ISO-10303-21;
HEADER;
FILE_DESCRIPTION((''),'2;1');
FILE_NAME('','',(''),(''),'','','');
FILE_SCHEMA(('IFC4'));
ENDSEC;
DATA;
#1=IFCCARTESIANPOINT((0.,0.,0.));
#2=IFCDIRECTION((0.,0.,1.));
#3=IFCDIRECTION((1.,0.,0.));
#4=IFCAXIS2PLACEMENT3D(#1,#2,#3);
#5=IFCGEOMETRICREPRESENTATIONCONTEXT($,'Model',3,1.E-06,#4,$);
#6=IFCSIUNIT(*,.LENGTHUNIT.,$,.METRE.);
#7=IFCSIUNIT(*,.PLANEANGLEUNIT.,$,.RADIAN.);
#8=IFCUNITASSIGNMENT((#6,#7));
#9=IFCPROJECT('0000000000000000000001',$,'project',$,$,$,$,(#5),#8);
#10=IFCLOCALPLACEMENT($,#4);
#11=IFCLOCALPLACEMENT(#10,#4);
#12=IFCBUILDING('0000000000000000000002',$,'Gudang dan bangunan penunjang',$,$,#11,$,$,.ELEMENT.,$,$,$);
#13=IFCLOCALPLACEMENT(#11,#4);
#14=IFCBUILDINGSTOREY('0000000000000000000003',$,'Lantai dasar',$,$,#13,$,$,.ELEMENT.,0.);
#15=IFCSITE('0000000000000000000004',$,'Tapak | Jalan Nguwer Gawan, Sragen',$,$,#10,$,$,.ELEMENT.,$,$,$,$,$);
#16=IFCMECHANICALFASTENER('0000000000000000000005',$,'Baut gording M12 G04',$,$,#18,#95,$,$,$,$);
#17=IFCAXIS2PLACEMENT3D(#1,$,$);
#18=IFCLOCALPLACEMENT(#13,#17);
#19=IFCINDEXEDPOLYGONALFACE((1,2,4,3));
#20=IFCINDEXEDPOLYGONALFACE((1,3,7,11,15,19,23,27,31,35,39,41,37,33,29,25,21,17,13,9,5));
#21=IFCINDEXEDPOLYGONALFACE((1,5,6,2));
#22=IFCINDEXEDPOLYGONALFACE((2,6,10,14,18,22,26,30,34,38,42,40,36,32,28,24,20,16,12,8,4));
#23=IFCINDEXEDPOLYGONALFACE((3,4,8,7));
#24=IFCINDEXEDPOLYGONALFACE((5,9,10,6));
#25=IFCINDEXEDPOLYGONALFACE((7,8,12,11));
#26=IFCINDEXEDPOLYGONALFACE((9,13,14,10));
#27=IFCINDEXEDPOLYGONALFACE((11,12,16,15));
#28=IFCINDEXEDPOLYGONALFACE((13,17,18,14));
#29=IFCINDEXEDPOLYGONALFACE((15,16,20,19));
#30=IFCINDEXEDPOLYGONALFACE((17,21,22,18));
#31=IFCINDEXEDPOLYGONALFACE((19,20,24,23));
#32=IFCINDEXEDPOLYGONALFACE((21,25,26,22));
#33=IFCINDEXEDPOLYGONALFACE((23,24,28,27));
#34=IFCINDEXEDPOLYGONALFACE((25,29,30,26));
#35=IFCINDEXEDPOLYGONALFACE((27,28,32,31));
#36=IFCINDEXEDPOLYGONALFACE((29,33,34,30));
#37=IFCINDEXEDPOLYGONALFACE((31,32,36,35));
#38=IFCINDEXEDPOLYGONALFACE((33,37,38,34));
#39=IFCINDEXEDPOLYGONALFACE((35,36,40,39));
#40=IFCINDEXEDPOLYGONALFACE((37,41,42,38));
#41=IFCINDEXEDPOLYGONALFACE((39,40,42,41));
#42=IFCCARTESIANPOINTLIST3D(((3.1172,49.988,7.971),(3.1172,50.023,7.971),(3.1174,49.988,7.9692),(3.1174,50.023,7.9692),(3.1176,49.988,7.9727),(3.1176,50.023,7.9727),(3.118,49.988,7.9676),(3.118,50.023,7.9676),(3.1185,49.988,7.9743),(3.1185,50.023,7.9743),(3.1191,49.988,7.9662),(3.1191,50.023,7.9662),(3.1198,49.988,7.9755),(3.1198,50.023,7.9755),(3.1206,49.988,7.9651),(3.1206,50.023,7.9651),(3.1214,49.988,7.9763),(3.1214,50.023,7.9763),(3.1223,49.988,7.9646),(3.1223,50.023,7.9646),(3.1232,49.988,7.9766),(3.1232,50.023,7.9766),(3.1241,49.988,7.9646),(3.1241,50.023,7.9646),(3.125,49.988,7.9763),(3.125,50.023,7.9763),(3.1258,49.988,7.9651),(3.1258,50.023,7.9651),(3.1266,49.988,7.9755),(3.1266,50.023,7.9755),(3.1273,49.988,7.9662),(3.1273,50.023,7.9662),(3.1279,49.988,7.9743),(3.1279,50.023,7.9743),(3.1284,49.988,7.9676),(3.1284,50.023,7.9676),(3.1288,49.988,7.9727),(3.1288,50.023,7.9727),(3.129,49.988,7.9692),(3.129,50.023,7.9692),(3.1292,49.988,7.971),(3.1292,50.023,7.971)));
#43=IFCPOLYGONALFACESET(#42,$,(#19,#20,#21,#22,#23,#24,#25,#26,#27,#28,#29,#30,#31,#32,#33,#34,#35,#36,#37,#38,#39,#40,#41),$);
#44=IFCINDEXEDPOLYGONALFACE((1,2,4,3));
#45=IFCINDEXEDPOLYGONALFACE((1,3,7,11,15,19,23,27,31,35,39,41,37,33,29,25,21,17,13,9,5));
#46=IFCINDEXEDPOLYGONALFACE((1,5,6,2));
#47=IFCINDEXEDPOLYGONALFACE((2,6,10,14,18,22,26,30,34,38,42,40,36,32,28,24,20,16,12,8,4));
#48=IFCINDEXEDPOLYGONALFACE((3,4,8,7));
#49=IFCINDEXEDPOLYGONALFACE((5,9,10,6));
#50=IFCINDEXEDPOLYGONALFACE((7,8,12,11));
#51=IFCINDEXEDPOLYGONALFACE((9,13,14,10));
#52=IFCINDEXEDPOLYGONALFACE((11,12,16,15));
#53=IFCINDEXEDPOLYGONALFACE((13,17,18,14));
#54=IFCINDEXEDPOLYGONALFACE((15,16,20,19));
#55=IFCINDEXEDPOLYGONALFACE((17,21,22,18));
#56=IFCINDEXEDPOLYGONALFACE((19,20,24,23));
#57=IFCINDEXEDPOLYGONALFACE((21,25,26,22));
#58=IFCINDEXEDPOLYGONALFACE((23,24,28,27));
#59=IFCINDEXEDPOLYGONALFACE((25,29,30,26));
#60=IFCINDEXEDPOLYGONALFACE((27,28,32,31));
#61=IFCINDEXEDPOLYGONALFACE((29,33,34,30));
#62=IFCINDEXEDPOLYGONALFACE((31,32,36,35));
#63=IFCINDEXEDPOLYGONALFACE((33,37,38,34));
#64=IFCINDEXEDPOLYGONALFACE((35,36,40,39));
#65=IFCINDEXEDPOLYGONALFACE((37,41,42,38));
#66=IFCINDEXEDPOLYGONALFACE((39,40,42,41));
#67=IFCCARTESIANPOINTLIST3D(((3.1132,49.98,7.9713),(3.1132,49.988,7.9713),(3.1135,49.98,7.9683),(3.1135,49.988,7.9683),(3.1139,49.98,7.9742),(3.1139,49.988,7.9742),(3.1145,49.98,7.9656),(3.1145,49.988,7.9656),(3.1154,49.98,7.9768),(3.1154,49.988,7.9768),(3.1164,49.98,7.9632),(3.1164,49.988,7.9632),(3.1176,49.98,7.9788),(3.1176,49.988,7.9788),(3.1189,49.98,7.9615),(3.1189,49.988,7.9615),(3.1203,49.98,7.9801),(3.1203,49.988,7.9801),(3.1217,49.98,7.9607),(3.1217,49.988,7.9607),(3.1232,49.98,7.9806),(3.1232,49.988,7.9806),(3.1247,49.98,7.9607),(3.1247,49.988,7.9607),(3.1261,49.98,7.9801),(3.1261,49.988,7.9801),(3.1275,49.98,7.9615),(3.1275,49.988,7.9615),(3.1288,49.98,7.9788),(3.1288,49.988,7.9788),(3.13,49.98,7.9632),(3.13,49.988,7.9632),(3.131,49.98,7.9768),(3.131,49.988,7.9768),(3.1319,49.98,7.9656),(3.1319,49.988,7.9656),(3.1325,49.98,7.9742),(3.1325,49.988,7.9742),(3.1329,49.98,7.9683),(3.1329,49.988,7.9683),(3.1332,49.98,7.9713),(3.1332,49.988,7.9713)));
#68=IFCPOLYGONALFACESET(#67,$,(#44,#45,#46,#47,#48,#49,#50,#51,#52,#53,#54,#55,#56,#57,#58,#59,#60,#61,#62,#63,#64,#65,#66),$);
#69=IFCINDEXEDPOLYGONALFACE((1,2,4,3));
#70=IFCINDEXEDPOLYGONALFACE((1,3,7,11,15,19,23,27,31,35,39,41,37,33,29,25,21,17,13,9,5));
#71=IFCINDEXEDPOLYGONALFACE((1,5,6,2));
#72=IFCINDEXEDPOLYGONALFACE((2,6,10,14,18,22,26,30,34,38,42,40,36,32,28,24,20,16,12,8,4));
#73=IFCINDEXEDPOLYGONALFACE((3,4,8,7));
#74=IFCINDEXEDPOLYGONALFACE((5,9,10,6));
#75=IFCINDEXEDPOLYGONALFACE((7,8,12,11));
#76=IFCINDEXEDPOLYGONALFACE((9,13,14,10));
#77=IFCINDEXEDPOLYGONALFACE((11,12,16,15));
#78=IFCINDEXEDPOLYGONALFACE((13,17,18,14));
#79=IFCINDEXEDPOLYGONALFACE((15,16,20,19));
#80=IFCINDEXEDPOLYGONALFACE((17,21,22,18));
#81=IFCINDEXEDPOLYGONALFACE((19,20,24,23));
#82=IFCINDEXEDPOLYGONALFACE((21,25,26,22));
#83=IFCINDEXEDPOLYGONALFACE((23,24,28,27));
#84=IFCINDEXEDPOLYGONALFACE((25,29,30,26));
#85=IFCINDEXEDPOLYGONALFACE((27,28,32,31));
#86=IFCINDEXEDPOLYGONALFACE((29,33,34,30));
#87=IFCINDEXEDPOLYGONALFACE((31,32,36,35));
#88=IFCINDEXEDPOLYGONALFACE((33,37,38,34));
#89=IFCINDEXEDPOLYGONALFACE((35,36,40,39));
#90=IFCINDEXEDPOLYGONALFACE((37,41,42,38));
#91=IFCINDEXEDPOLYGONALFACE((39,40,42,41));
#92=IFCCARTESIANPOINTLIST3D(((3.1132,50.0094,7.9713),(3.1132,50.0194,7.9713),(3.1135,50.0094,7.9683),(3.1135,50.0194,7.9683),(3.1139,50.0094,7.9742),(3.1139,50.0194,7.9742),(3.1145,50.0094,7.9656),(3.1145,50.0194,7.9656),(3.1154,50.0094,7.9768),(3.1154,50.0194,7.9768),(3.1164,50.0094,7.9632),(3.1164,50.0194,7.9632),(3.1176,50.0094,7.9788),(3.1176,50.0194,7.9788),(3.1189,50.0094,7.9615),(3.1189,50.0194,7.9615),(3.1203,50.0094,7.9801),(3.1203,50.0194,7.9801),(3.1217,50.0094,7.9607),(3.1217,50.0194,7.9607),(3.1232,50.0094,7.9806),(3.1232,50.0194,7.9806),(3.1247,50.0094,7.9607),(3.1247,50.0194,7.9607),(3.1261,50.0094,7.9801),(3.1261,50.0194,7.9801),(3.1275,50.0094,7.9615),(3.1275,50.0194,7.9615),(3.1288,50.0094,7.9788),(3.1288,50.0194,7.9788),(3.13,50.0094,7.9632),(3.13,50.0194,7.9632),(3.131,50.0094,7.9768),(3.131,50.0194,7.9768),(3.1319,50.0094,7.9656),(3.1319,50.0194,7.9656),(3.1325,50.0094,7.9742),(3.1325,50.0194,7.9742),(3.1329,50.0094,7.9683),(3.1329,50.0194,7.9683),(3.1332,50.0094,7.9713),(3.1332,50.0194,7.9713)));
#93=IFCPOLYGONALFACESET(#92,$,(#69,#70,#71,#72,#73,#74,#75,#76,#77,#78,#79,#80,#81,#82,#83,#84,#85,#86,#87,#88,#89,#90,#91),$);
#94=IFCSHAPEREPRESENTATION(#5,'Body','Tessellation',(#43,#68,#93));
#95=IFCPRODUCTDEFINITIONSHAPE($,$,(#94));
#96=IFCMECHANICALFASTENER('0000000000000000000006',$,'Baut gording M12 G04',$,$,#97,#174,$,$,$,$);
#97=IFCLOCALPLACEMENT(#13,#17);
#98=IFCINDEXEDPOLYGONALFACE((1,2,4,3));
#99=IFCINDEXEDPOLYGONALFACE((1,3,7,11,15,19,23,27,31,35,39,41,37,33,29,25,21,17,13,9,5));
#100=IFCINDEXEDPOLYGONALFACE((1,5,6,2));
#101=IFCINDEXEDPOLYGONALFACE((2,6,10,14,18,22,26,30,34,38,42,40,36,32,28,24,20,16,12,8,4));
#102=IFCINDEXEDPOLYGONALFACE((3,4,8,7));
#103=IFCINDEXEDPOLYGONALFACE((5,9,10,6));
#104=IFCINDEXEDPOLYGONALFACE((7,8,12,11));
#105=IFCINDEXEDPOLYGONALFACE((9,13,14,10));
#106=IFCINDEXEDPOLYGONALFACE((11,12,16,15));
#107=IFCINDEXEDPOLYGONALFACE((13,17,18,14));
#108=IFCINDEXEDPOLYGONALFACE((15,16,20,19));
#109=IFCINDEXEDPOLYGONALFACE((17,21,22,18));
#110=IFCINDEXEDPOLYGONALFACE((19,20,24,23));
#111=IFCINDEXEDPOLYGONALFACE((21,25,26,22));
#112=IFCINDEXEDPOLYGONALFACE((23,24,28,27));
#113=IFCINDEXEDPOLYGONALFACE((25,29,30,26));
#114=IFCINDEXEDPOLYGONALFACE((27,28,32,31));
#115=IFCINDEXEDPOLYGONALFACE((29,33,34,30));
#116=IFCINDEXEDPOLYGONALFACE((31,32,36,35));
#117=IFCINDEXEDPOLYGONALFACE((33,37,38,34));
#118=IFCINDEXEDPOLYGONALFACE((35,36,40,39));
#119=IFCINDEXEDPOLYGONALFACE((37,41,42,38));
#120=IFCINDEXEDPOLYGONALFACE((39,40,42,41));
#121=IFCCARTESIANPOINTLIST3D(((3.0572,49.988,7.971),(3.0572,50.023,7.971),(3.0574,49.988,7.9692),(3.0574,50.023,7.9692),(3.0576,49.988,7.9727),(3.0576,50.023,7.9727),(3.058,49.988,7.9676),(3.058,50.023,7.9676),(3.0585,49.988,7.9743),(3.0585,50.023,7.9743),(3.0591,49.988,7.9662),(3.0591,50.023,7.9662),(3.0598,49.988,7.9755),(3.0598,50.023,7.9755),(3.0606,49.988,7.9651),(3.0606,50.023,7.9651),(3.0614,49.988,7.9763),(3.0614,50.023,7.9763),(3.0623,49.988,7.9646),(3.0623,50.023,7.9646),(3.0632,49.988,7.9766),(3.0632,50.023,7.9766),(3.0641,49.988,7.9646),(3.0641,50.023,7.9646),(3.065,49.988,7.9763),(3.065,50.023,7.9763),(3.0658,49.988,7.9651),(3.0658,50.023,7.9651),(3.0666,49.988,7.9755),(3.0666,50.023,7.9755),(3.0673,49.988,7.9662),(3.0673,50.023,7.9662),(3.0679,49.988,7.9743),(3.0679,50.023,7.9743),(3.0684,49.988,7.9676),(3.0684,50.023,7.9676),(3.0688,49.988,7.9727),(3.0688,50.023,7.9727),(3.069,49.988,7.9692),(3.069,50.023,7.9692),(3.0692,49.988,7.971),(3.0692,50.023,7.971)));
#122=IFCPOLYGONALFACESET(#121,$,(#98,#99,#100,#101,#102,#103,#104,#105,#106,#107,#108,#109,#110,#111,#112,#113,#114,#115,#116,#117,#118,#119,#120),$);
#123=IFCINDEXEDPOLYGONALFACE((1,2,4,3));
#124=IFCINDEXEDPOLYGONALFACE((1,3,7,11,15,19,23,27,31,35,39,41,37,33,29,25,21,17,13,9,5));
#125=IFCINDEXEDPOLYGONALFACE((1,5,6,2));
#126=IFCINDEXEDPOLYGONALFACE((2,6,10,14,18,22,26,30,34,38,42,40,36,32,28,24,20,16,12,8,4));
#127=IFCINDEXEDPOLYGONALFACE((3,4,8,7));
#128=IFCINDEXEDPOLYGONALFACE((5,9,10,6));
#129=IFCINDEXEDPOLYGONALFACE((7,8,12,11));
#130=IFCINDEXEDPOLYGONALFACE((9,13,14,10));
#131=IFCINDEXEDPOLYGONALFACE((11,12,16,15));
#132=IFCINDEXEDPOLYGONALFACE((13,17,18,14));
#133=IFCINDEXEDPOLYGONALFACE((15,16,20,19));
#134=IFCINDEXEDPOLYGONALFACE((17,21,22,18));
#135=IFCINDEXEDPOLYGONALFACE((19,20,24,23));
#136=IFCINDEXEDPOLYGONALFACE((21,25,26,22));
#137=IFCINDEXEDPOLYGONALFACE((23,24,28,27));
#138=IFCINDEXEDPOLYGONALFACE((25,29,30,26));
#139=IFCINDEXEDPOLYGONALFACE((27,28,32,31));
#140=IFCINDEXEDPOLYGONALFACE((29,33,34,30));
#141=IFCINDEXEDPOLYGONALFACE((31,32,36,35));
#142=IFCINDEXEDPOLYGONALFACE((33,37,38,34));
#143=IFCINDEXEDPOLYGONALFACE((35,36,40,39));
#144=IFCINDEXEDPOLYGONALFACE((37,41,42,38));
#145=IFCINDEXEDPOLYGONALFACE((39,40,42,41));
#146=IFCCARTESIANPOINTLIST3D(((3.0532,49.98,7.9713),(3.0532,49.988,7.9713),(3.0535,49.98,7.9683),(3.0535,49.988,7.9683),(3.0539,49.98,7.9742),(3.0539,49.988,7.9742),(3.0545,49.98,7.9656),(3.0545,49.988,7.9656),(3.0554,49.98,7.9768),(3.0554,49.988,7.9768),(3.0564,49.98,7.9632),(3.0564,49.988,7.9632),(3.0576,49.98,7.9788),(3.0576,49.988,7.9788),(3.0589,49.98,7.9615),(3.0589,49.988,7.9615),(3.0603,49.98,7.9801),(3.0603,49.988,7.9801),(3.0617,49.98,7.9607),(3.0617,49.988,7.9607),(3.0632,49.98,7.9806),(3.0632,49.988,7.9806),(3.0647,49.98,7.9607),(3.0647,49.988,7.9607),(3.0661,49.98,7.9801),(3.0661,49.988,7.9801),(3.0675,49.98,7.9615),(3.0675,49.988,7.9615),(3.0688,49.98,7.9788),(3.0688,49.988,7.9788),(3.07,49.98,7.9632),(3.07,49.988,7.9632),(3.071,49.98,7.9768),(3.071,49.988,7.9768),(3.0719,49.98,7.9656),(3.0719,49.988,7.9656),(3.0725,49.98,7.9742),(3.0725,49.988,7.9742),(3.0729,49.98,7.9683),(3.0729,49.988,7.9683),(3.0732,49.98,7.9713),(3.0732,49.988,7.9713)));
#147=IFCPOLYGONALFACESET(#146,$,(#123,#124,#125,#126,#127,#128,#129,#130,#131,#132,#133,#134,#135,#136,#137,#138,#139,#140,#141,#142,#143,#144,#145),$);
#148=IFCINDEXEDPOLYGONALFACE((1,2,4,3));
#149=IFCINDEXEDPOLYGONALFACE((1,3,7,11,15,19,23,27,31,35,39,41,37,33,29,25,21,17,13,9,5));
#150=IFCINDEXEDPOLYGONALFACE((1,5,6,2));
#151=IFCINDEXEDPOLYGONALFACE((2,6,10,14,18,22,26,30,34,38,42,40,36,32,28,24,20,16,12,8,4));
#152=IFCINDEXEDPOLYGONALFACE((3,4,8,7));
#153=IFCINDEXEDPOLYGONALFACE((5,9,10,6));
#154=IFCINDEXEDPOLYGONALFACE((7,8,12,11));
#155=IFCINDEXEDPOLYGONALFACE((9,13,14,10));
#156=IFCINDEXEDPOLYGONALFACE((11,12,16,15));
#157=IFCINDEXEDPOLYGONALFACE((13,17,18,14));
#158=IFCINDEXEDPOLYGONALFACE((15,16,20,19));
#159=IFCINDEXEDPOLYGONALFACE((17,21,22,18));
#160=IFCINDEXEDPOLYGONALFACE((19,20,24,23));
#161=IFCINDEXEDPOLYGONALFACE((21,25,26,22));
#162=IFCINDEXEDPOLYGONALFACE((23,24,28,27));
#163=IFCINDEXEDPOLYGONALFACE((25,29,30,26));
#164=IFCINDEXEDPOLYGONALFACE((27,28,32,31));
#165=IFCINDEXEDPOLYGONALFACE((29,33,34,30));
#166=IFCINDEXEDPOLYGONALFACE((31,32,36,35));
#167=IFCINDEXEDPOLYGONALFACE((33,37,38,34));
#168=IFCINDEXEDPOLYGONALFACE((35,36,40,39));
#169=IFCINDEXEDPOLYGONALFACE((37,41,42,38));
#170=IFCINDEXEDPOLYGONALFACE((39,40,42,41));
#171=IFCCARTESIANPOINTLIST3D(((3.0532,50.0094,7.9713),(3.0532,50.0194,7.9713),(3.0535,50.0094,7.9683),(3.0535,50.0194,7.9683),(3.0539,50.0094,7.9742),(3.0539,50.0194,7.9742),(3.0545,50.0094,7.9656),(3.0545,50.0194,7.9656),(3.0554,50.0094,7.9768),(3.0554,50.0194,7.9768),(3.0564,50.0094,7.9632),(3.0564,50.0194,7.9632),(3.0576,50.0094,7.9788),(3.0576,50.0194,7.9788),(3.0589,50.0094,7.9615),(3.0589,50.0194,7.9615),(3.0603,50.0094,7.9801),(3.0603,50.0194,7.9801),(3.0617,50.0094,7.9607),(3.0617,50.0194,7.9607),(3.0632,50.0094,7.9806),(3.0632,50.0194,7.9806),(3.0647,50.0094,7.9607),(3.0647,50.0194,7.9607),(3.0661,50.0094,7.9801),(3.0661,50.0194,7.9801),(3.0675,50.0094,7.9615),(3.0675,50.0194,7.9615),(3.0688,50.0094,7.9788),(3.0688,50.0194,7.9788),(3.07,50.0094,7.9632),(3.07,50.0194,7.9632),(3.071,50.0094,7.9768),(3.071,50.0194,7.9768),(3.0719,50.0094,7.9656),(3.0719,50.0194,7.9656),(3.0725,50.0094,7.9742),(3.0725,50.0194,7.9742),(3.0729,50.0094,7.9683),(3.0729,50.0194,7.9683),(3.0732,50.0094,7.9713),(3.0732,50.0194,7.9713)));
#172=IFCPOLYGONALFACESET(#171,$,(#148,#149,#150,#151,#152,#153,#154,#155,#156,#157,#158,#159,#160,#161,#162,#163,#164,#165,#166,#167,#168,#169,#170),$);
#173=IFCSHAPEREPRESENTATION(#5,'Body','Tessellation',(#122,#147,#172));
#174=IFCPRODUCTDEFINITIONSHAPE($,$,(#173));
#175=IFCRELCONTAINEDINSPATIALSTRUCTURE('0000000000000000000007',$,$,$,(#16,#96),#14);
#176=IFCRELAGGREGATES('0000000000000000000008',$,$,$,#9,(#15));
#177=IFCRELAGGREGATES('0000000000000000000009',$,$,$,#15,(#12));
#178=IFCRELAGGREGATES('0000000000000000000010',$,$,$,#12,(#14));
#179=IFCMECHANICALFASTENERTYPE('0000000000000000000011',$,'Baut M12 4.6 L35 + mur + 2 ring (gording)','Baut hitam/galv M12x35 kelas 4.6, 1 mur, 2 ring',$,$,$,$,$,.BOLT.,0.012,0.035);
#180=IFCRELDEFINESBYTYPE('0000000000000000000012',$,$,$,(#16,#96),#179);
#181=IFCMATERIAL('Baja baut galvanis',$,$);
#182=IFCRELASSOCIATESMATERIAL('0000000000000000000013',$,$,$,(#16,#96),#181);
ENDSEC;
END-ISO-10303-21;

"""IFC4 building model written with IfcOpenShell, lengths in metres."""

from ifc_helpers import new_model, si_unit, frame, origin_with_axes, place, context, project, spatial, circle, extrude, source, transform, mapped, material, type_object, type_shapes, element, save


model = new_model("IFC4")

# Units and contexts
model_context = context("Model", 3, precision=1e-06, world=origin_with_axes())
ifc_project = project(units=[si_unit("LENGTHUNIT", "METRE"), si_unit("PLANEANGLEUNIT", "RADIAN")], contexts=[model_context])

# Site, building, storey
site_placement = place(None, origin_with_axes())
site = spatial("IfcSite", under=ifc_project, at=site_placement, Name="Tapak | Jalan Nguwer Gawan, Sragen", CompositionType="ELEMENT")
building_placement = place(site_placement, origin_with_axes())
building = spatial("IfcBuilding", under=site, at=building_placement, Name="Gudang dan bangunan penunjang", CompositionType="ELEMENT")
storey_placement = place(building_placement, origin_with_axes())
storey = spatial("IfcBuildingStorey", under=building, at=storey_placement, Name="Lantai dasar", CompositionType="ELEMENT", Elevation=0.0)

# Shared definitions
placement = place(None, origin_with_axes())

# Mechanical fasteners
ifc_material_1 = material(Name="Baja baut galvanis")
mechanical_fastener_type = type_object("IfcMechanicalFastenerType", Name="Baut M12 4.6 L35 + mur + 2 ring (gording)", Description="Baut hitam/galv M12x35 kelas 4.6, 1 mur, 2 ring", NominalDiameter=0.012, NominalLength=0.035, PredefinedType="BOLT")
shared_shape = source(origin_with_axes(), model_context, "Body", "SweptSolid", [
    extrude(circle(Radius=0.006), origin_with_axes(), (0.0, 0.0, 1.0), 0.035),
    extrude(circle(Radius=0.01), frame((0.0, 0.0, -0.008), z_axis=(0.0, 0.0, 1.0), x_axis=(1.0, 0.0, 0.0)), (0.0, 0.0, 1.0), 0.008),
    extrude(circle(Radius=0.01), frame((0.0, 0.0, 0.0214), z_axis=(0.0, 0.0, 1.0), x_axis=(1.0, 0.0, 0.0)), (0.0, 0.0, 1.0), 0.01),
])
type_shapes(mechanical_fastener_type, [shared_shape])
element("IfcMechanicalFastener", 1, at=placement, inside=storey, type_object=mechanical_fastener_type, material=ifc_material_1, Name="Baut gording M12 G04", context=model_context, shape_type="MappedRepresentation", body=[
    mapped(shared_shape, transform((3.1232, 49.988, 7.9706), x_axis=(0.0, 0.0, 1.0), y_axis=(1.0, 0.0, 0.0), z_axis=(0.0, 1.0, 0.0), scale=1.0)),
])
element("IfcMechanicalFastener", 2, at=placement, inside=storey, type_object=mechanical_fastener_type, material=ifc_material_1, Name="Baut gording M12 G04", context=model_context, shape_type="MappedRepresentation", body=[
    mapped(shared_shape, transform((3.0632, 49.988, 7.9706), x_axis=(0.0, 0.0, 1.0), y_axis=(1.0, 0.0, 0.0), z_axis=(0.0, 1.0, 0.0), scale=1.0)),
])

save(model, "model.ifc")
